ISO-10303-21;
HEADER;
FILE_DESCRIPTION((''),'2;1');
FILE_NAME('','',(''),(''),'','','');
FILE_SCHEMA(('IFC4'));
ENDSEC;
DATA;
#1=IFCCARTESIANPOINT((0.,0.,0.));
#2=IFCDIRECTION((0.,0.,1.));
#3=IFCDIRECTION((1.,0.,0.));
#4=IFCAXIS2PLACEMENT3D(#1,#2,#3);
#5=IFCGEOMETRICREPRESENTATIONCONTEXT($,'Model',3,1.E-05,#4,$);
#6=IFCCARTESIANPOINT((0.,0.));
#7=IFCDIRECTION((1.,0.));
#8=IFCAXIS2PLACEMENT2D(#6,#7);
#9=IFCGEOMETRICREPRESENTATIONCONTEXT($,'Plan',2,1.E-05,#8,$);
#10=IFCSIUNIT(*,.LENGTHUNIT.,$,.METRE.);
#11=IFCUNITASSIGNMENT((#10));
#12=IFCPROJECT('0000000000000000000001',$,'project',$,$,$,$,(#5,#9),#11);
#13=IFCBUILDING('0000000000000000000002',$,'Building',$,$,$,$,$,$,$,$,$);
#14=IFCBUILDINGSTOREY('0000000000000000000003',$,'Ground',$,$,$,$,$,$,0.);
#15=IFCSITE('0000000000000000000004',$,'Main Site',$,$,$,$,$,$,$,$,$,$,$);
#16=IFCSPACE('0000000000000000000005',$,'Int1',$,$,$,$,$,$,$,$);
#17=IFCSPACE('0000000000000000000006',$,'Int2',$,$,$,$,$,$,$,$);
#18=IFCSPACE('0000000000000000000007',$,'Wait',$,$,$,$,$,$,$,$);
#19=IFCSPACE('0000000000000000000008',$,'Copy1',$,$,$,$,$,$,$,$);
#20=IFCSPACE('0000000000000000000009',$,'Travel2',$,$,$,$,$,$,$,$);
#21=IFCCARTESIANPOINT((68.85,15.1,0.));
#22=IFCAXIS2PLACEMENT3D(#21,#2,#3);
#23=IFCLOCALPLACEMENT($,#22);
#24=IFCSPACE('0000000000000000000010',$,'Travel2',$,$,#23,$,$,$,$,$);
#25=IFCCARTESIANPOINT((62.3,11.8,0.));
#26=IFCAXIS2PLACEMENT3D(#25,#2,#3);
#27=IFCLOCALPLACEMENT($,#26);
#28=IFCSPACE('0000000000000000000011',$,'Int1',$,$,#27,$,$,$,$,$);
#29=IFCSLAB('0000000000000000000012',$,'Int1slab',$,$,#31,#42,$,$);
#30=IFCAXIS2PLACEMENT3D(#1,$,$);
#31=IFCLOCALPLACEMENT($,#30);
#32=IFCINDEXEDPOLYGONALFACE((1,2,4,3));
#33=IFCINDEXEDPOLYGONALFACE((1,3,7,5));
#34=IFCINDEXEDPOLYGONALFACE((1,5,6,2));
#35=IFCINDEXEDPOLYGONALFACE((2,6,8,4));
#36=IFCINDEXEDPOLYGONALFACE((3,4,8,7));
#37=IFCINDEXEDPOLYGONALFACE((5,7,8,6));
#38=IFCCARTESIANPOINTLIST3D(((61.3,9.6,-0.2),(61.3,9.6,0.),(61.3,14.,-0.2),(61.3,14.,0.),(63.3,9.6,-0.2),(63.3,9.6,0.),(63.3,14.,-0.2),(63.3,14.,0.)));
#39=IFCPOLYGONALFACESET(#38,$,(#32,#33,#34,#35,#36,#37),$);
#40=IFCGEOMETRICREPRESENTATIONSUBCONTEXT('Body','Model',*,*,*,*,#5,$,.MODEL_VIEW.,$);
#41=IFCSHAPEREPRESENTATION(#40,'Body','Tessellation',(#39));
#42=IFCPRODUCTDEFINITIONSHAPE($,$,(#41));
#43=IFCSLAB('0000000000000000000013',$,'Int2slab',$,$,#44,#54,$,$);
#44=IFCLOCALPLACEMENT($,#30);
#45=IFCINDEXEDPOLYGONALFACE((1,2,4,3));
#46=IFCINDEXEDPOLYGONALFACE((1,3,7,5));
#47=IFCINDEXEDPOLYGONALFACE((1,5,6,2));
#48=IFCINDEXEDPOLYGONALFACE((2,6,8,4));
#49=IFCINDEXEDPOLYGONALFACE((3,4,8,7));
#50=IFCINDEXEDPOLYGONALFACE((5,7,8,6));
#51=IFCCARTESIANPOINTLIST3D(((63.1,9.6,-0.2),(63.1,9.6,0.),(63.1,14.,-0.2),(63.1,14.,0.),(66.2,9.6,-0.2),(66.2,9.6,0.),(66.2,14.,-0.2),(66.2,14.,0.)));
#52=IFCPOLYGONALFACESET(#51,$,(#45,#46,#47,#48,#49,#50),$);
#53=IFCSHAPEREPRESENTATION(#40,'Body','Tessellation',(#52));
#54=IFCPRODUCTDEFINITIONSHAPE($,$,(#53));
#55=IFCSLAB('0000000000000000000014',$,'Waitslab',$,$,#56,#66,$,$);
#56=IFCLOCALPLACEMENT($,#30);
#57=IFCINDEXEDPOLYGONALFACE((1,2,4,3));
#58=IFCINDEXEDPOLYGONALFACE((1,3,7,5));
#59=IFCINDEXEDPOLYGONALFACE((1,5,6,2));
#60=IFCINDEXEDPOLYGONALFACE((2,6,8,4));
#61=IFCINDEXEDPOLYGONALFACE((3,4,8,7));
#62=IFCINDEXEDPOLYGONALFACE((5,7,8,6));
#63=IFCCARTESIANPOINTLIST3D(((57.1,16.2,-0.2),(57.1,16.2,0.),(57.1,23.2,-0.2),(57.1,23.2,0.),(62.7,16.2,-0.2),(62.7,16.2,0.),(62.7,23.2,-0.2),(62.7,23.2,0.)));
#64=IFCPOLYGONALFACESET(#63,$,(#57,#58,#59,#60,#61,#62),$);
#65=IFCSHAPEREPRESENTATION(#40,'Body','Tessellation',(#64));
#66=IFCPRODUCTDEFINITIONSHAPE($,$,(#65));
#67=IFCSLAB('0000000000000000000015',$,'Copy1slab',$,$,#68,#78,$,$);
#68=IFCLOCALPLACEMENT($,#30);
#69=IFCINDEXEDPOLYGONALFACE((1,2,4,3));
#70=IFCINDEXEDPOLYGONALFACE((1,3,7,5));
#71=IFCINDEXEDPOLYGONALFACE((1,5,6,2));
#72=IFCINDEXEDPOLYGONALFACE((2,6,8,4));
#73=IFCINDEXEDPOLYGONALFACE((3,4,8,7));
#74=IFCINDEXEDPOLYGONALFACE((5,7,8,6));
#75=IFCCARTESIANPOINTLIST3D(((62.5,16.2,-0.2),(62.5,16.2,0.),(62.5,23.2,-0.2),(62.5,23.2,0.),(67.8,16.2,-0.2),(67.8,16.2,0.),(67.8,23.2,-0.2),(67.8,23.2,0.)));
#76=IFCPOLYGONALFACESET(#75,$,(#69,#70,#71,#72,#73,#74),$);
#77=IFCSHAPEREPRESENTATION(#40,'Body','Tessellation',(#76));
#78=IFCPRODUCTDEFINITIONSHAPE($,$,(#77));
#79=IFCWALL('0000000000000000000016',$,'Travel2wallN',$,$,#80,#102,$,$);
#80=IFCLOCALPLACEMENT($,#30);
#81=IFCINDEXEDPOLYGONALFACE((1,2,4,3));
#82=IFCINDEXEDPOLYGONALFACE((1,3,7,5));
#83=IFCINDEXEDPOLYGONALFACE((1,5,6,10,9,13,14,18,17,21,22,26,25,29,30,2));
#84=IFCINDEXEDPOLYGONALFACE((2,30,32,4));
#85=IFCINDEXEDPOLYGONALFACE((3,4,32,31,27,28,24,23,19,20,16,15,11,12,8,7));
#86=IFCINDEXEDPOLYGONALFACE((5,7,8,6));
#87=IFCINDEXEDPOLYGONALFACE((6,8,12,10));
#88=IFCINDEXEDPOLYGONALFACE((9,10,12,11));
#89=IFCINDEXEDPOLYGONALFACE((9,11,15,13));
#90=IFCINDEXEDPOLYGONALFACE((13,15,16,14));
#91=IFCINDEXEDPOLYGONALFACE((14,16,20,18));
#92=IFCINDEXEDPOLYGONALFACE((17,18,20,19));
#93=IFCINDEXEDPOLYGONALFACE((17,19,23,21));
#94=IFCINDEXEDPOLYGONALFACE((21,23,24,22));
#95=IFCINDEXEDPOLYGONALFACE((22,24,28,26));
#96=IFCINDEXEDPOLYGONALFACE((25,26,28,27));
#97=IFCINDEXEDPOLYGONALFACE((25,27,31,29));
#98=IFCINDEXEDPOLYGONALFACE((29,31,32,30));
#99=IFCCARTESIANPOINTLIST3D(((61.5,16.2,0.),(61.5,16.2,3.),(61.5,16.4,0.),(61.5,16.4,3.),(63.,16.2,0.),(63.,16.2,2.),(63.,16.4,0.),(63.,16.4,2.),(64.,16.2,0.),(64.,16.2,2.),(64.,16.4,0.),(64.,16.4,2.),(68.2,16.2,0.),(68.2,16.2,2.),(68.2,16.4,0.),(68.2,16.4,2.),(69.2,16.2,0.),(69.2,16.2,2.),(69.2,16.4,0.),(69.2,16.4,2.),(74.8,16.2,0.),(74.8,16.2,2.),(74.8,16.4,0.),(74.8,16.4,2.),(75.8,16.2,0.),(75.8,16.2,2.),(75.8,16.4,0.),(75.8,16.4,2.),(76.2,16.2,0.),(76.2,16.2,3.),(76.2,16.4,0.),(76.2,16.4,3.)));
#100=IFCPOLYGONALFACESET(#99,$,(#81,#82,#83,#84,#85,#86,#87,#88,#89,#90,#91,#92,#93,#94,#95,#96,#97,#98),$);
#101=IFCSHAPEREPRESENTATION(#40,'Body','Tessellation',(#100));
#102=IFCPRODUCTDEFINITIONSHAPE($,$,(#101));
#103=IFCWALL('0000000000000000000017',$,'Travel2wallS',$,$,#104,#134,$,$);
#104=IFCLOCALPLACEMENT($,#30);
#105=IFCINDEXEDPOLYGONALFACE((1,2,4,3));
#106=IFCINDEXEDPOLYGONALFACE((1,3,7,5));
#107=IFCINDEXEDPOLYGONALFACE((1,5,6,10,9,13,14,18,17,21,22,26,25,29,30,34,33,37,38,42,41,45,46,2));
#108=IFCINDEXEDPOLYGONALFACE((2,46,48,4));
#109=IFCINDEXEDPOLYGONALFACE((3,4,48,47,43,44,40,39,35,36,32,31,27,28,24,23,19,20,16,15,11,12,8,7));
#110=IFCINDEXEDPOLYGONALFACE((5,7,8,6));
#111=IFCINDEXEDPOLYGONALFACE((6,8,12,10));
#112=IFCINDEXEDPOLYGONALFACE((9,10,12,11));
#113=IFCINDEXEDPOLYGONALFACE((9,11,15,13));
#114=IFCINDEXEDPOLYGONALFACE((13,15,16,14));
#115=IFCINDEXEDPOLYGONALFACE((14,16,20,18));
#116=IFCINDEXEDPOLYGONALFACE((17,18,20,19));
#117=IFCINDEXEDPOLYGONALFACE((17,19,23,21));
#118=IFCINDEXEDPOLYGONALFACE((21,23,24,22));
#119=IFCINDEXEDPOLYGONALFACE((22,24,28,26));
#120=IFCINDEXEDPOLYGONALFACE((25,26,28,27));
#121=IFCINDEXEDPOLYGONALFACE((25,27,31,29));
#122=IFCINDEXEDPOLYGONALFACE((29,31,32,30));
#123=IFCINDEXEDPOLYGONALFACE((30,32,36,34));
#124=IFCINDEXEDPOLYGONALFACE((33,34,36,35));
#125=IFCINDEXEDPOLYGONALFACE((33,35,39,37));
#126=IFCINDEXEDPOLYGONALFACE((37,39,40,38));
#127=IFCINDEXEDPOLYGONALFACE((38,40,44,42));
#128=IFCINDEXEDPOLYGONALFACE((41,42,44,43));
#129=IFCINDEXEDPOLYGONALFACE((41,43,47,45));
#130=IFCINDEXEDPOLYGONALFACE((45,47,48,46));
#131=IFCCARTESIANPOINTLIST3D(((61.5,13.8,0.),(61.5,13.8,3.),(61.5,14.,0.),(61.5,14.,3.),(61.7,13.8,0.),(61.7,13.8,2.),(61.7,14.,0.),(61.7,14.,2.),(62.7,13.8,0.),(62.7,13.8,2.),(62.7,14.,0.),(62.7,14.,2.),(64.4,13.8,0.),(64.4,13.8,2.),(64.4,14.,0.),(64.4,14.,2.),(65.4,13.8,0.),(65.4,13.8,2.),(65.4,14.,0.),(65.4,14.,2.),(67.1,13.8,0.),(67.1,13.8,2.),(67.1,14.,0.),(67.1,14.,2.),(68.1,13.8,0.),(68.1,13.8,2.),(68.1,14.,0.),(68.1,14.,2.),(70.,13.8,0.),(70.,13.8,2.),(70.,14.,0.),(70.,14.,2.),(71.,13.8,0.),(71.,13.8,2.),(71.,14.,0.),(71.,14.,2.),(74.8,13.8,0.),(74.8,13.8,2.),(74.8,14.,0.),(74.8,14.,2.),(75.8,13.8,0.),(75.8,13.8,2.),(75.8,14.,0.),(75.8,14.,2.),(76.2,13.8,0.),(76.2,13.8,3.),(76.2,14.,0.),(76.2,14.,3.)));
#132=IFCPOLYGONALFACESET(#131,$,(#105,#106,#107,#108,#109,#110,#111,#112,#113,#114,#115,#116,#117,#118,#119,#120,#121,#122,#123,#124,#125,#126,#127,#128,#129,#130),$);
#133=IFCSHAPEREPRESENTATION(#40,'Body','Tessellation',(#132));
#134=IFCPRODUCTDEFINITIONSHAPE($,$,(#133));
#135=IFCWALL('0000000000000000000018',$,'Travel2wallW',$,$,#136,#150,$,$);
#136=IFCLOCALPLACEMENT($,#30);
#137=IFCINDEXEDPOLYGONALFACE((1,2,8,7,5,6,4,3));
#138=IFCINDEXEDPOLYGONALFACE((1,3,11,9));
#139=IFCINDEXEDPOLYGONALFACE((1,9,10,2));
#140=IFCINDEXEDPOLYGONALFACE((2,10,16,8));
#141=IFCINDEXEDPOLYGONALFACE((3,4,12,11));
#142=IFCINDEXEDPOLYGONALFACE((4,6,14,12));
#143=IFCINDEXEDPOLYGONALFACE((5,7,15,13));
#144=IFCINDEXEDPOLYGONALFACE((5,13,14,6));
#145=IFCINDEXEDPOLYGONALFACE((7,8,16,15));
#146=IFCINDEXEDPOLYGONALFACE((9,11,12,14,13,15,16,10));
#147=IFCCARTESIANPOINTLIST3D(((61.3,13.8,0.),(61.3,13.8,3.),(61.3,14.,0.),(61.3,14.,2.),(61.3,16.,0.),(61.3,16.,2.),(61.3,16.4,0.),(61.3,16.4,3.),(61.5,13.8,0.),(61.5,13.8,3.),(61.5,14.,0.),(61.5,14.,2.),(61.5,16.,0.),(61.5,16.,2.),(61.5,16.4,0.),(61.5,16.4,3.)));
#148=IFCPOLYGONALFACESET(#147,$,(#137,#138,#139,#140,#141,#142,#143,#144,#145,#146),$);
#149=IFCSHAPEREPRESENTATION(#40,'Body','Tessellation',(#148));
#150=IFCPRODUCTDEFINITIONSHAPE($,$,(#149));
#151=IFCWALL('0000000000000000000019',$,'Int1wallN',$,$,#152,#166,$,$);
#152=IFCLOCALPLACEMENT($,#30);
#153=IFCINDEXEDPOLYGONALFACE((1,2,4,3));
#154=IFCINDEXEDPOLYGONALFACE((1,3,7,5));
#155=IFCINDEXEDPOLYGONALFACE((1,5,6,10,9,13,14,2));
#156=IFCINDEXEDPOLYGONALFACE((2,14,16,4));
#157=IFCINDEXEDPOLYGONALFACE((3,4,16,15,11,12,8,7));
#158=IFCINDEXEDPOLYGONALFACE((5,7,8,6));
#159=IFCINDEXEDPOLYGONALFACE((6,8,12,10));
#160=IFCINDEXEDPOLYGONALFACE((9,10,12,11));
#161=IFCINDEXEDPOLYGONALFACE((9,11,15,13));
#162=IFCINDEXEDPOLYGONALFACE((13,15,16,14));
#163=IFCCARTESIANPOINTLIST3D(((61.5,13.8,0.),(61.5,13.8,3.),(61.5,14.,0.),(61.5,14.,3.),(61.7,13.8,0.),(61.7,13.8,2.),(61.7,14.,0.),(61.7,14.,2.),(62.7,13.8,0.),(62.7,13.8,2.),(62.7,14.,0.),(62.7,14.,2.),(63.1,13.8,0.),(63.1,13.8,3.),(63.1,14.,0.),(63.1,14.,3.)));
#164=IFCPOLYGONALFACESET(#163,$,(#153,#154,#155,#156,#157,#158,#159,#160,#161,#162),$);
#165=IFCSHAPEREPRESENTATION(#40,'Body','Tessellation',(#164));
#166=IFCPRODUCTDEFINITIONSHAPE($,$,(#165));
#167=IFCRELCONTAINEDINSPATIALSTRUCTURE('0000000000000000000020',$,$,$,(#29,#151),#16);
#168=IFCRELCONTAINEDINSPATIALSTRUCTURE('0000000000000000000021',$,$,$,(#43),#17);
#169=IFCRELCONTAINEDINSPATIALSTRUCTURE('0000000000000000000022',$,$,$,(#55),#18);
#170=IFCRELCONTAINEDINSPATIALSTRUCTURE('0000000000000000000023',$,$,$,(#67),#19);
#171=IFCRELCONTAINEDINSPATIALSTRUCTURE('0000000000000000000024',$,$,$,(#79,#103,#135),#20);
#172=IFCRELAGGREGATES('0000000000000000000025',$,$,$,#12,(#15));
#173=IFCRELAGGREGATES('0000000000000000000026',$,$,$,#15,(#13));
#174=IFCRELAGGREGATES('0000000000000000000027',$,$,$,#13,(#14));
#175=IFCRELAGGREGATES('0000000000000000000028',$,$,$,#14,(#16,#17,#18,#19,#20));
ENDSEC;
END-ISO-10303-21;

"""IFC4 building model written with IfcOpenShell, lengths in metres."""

from ifc_helpers import new_model, si_unit, frame, origin_with_axes, origin_2d_with_axis, place, context, subcontext, project, spatial, indexed_curve, rectangle, outline, extrude, element, save


model = new_model("IFC4")

# Units and contexts
model_context = context("Model", 3, precision=1e-05, world=origin_with_axes())
plan_context = context("Plan", 2, precision=1e-05, world=origin_2d_with_axis())
body_context = subcontext(model_context, "Body", "Model", "MODEL_VIEW")
ifc_project = project(units=[si_unit("LENGTHUNIT", "METRE")], contexts=[model_context, plan_context])

# Site, building, storey, space
site = spatial("IfcSite", under=ifc_project, Name="Main Site")
building = spatial("IfcBuilding", under=site, Name="Building")
storey = spatial("IfcBuildingStorey", under=building, Name="Ground", Elevation=0.0)
space_1 = spatial("IfcSpace", under=storey, Name="Int1")

# Slab
slab_1_placement = place(None, frame((62.3, 11.8, -0.2), z_axis=(0.0, 0.0, 1.0), x_axis=(1.0, 0.0, 0.0)))
element("IfcSlab", 1, at=slab_1_placement, inside=space_1, Name="Int1slab", context=body_context, shape_type="SweptSolid", body=[
    extrude(rectangle(XDim=2.0, YDim=4.4), origin_with_axes(), (0.0, 0.0, 1.0), 0.2),
])

# Shared definitions
space_2 = spatial("IfcSpace", under=storey, Name="Int2")

# Slab
slab_2_placement = place(None, frame((64.65, 11.8, -0.2), z_axis=(0.0, 0.0, 1.0), x_axis=(1.0, 0.0, 0.0)))
element("IfcSlab", 2, at=slab_2_placement, inside=space_2, Name="Int2slab", context=body_context, shape_type="SweptSolid", body=[
    extrude(rectangle(XDim=3.1, YDim=4.4), origin_with_axes(), (0.0, 0.0, 1.0), 0.2),
])

# Shared definitions
space_3 = spatial("IfcSpace", under=storey, Name="Wait")

# Slab
slab_3_placement = place(None, frame((59.9, 19.7, -0.2), z_axis=(0.0, 0.0, 1.0), x_axis=(1.0, 0.0, 0.0)))
element("IfcSlab", 3, at=slab_3_placement, inside=space_3, Name="Waitslab", context=body_context, shape_type="SweptSolid", body=[
    extrude(rectangle(XDim=5.6, YDim=7.0), origin_with_axes(), (0.0, 0.0, 1.0), 0.2),
])

# Shared definitions
space_4 = spatial("IfcSpace", under=storey, Name="Copy1")

# Slab
slab_4_placement = place(None, frame((65.15, 19.7, -0.2), z_axis=(0.0, 0.0, 1.0), x_axis=(1.0, 0.0, 0.0)))
element("IfcSlab", 4, at=slab_4_placement, inside=space_4, Name="Copy1slab", context=body_context, shape_type="SweptSolid", body=[
    extrude(rectangle(XDim=5.3, YDim=7.0), origin_with_axes(), (0.0, 0.0, 1.0), 0.2),
])

# Shared definitions
space_5 = spatial("IfcSpace", under=storey, Name="Travel2")

# Wall
wall_1_placement = place(None, frame((61.5, 16.2, 0.0), z_axis=(0.0, 0.0, 1.0), x_axis=(1.0, 0.0, 0.0)))
wall_1 = element("IfcWall", 5, at=wall_1_placement, inside=space_5, Name="Travel2wallN", context=body_context, shape_type="SweptSolid", body=[
    extrude(outline(indexed_curve([(0.0, 0.0), (0.0, 0.2), (14.7, 0.2), (14.7, 0.0), (0.0, 0.0)], self_intersect=False)), origin_with_axes(), (0.0, 0.0, 1.0), 3.0),
])

# Shared definitions
space_6_placement = place(None, frame((68.85, 15.1, 0.0), z_axis=(0.0, 0.0, 1.0), x_axis=(1.0, 0.0, 0.0)))
space_6 = spatial("IfcSpace", at=space_6_placement, Name="Travel2")

# Openings
opening_1_placement = place(wall_1_placement, frame((1.5, 0.0, 0.0), z_axis=(0.0, 0.0, 1.0), x_axis=(1.0, 0.0, 0.0)))
element("IfcOpeningElement", 6, at=opening_1_placement, inside=space_6, cuts=wall_1, context=body_context, shape_type="SweptSolid", body=[
    extrude(outline(indexed_curve([(0.0, 0.0), (0.0, 0.4), (1.0, 0.4), (1.0, 0.0), (0.0, 0.0)], self_intersect=False)), origin_with_axes(), (0.0, 0.0, 1.0), 2.0),
])
opening_2_placement = place(wall_1_placement, frame((6.7, 0.0, 0.0), z_axis=(0.0, 0.0, 1.0), x_axis=(1.0, 0.0, 0.0)))
element("IfcOpeningElement", 7, at=opening_2_placement, inside=space_6, cuts=wall_1, context=body_context, shape_type="SweptSolid", body=[
    extrude(outline(indexed_curve([(0.0, 0.0), (0.0, 0.4), (1.0, 0.4), (1.0, 0.0), (0.0, 0.0)], self_intersect=False)), origin_with_axes(), (0.0, 0.0, 1.0), 2.0),
])
opening_3_placement = place(wall_1_placement, frame((13.3, 0.0, 0.0), z_axis=(0.0, 0.0, 1.0), x_axis=(1.0, 0.0, 0.0)))
element("IfcOpeningElement", 8, at=opening_3_placement, inside=space_6, cuts=wall_1, context=body_context, shape_type="SweptSolid", body=[
    extrude(outline(indexed_curve([(0.0, 0.0), (0.0, 0.4), (1.0, 0.4), (1.0, 0.0), (0.0, 0.0)], self_intersect=False)), origin_with_axes(), (0.0, 0.0, 1.0), 2.0),
])

# Wall, openings
wall_2_placement = place(None, frame((61.5, 13.8, 0.0), z_axis=(0.0, 0.0, 1.0), x_axis=(1.0, 0.0, 0.0)))
wall_2 = element("IfcWall", 9, at=wall_2_placement, inside=space_5, Name="Travel2wallS", context=body_context, shape_type="SweptSolid", body=[
    extrude(outline(indexed_curve([(0.0, 0.0), (0.0, 0.2), (14.7, 0.2), (14.7, 0.0), (0.0, 0.0)], self_intersect=False)), origin_with_axes(), (0.0, 0.0, 1.0), 3.0),
])
opening_4_placement = place(wall_2_placement, frame((0.2, 0.0, 0.0), z_axis=(0.0, 0.0, 1.0), x_axis=(1.0, 0.0, 0.0)))
element("IfcOpeningElement", 10, at=opening_4_placement, inside=space_6, cuts=wall_2, context=body_context, shape_type="SweptSolid", body=[
    extrude(outline(indexed_curve([(0.0, 0.0), (0.0, 0.4), (1.0, 0.4), (1.0, 0.0), (0.0, 0.0)], self_intersect=False)), origin_with_axes(), (0.0, 0.0, 1.0), 2.0),
])
opening_5_placement = place(wall_2_placement, frame((2.9, 0.0, 0.0), z_axis=(0.0, 0.0, 1.0), x_axis=(1.0, 0.0, 0.0)))
element("IfcOpeningElement", 11, at=opening_5_placement, inside=space_6, cuts=wall_2, context=body_context, shape_type="SweptSolid", body=[
    extrude(outline(indexed_curve([(0.0, 0.0), (0.0, 0.4), (1.0, 0.4), (1.0, 0.0), (0.0, 0.0)], self_intersect=False)), origin_with_axes(), (0.0, 0.0, 1.0), 2.0),
])
opening_6_placement = place(wall_2_placement, frame((5.6, 0.0, 0.0), z_axis=(0.0, 0.0, 1.0), x_axis=(1.0, 0.0, 0.0)))
element("IfcOpeningElement", 12, at=opening_6_placement, inside=space_6, cuts=wall_2, context=body_context, shape_type="SweptSolid", body=[
    extrude(outline(indexed_curve([(0.0, 0.0), (0.0, 0.4), (1.0, 0.4), (1.0, 0.0), (0.0, 0.0)], self_intersect=False)), origin_with_axes(), (0.0, 0.0, 1.0), 2.0),
])
opening_7_placement = place(wall_2_placement, frame((8.5, 0.0, 0.0), z_axis=(0.0, 0.0, 1.0), x_axis=(1.0, 0.0, 0.0)))
element("IfcOpeningElement", 13, at=opening_7_placement, inside=space_6, cuts=wall_2, context=body_context, shape_type="SweptSolid", body=[
    extrude(outline(indexed_curve([(0.0, 0.0), (0.0, 0.4), (1.0, 0.4), (1.0, 0.0), (0.0, 0.0)], self_intersect=False)), origin_with_axes(), (0.0, 0.0, 1.0), 2.0),
])
opening_8_placement = place(wall_2_placement, frame((13.3, 0.0, 0.0), z_axis=(0.0, 0.0, 1.0), x_axis=(1.0, 0.0, 0.0)))
element("IfcOpeningElement", 14, at=opening_8_placement, inside=space_6, cuts=wall_2, context=body_context, shape_type="SweptSolid", body=[
    extrude(outline(indexed_curve([(0.0, 0.0), (0.0, 0.4), (1.0, 0.4), (1.0, 0.0), (0.0, 0.0)], self_intersect=False)), origin_with_axes(), (0.0, 0.0, 1.0), 2.0),
])

# Wall, opening
wall_3_placement = place(None, frame((61.5, 13.8, 0.0), z_axis=(0.0, 0.0, 1.0), x_axis=(0.0, 1.0, 0.0)))
wall_3 = element("IfcWall", 15, at=wall_3_placement, inside=space_5, Name="Travel2wallW", context=body_context, shape_type="SweptSolid", body=[
    extrude(outline(indexed_curve([(0.0, 0.0), (0.0, 0.2), (2.6, 0.2), (2.6, 0.0), (0.0, 0.0)], self_intersect=False)), origin_with_axes(), (0.0, 0.0, 1.0), 3.0),
])
opening_9_placement = place(wall_3_placement, frame((0.2, 0.0, 0.0), z_axis=(0.0, 0.0, 1.0), x_axis=(1.0, 0.0, 0.0)))
element("IfcOpeningElement", 16, at=opening_9_placement, inside=space_6, cuts=wall_3, context=body_context, shape_type="SweptSolid", body=[
    extrude(outline(indexed_curve([(0.0, 0.0), (0.0, 0.4), (2.0, 0.4), (2.0, 0.0), (0.0, 0.0)], self_intersect=False)), origin_with_axes(), (0.0, 0.0, 1.0), 2.0),
])

# Wall
wall_4_placement = place(None, frame((61.5, 13.8, 0.0), z_axis=(0.0, 0.0, 1.0), x_axis=(1.0, 0.0, 0.0)))
wall_4 = element("IfcWall", 17, at=wall_4_placement, inside=space_1, Name="Int1wallN", context=body_context, shape_type="SweptSolid", body=[
    extrude(outline(indexed_curve([(0.0, 0.0), (0.0, 0.2), (1.6, 0.2), (1.6, 0.0), (0.0, 0.0)], self_intersect=False)), origin_with_axes(), (0.0, 0.0, 1.0), 3.0),
])

# Shared definitions
space_7_placement = place(None, frame((62.3, 11.8, 0.0), z_axis=(0.0, 0.0, 1.0), x_axis=(1.0, 0.0, 0.0)))
space_7 = spatial("IfcSpace", at=space_7_placement, Name="Int1")

# Opening
opening_10_placement = place(wall_4_placement, frame((0.2, 0.0, 0.0), z_axis=(0.0, 0.0, 1.0), x_axis=(1.0, 0.0, 0.0)))
element("IfcOpeningElement", 18, at=opening_10_placement, inside=space_7, cuts=wall_4, context=body_context, shape_type="SweptSolid", body=[
    extrude(outline(indexed_curve([(0.0, 0.0), (0.0, 0.4), (1.0, 0.4), (1.0, 0.0), (0.0, 0.0)], self_intersect=False)), origin_with_axes(), (0.0, 0.0, 1.0), 2.0),
])

save(model, "model.ifc")
